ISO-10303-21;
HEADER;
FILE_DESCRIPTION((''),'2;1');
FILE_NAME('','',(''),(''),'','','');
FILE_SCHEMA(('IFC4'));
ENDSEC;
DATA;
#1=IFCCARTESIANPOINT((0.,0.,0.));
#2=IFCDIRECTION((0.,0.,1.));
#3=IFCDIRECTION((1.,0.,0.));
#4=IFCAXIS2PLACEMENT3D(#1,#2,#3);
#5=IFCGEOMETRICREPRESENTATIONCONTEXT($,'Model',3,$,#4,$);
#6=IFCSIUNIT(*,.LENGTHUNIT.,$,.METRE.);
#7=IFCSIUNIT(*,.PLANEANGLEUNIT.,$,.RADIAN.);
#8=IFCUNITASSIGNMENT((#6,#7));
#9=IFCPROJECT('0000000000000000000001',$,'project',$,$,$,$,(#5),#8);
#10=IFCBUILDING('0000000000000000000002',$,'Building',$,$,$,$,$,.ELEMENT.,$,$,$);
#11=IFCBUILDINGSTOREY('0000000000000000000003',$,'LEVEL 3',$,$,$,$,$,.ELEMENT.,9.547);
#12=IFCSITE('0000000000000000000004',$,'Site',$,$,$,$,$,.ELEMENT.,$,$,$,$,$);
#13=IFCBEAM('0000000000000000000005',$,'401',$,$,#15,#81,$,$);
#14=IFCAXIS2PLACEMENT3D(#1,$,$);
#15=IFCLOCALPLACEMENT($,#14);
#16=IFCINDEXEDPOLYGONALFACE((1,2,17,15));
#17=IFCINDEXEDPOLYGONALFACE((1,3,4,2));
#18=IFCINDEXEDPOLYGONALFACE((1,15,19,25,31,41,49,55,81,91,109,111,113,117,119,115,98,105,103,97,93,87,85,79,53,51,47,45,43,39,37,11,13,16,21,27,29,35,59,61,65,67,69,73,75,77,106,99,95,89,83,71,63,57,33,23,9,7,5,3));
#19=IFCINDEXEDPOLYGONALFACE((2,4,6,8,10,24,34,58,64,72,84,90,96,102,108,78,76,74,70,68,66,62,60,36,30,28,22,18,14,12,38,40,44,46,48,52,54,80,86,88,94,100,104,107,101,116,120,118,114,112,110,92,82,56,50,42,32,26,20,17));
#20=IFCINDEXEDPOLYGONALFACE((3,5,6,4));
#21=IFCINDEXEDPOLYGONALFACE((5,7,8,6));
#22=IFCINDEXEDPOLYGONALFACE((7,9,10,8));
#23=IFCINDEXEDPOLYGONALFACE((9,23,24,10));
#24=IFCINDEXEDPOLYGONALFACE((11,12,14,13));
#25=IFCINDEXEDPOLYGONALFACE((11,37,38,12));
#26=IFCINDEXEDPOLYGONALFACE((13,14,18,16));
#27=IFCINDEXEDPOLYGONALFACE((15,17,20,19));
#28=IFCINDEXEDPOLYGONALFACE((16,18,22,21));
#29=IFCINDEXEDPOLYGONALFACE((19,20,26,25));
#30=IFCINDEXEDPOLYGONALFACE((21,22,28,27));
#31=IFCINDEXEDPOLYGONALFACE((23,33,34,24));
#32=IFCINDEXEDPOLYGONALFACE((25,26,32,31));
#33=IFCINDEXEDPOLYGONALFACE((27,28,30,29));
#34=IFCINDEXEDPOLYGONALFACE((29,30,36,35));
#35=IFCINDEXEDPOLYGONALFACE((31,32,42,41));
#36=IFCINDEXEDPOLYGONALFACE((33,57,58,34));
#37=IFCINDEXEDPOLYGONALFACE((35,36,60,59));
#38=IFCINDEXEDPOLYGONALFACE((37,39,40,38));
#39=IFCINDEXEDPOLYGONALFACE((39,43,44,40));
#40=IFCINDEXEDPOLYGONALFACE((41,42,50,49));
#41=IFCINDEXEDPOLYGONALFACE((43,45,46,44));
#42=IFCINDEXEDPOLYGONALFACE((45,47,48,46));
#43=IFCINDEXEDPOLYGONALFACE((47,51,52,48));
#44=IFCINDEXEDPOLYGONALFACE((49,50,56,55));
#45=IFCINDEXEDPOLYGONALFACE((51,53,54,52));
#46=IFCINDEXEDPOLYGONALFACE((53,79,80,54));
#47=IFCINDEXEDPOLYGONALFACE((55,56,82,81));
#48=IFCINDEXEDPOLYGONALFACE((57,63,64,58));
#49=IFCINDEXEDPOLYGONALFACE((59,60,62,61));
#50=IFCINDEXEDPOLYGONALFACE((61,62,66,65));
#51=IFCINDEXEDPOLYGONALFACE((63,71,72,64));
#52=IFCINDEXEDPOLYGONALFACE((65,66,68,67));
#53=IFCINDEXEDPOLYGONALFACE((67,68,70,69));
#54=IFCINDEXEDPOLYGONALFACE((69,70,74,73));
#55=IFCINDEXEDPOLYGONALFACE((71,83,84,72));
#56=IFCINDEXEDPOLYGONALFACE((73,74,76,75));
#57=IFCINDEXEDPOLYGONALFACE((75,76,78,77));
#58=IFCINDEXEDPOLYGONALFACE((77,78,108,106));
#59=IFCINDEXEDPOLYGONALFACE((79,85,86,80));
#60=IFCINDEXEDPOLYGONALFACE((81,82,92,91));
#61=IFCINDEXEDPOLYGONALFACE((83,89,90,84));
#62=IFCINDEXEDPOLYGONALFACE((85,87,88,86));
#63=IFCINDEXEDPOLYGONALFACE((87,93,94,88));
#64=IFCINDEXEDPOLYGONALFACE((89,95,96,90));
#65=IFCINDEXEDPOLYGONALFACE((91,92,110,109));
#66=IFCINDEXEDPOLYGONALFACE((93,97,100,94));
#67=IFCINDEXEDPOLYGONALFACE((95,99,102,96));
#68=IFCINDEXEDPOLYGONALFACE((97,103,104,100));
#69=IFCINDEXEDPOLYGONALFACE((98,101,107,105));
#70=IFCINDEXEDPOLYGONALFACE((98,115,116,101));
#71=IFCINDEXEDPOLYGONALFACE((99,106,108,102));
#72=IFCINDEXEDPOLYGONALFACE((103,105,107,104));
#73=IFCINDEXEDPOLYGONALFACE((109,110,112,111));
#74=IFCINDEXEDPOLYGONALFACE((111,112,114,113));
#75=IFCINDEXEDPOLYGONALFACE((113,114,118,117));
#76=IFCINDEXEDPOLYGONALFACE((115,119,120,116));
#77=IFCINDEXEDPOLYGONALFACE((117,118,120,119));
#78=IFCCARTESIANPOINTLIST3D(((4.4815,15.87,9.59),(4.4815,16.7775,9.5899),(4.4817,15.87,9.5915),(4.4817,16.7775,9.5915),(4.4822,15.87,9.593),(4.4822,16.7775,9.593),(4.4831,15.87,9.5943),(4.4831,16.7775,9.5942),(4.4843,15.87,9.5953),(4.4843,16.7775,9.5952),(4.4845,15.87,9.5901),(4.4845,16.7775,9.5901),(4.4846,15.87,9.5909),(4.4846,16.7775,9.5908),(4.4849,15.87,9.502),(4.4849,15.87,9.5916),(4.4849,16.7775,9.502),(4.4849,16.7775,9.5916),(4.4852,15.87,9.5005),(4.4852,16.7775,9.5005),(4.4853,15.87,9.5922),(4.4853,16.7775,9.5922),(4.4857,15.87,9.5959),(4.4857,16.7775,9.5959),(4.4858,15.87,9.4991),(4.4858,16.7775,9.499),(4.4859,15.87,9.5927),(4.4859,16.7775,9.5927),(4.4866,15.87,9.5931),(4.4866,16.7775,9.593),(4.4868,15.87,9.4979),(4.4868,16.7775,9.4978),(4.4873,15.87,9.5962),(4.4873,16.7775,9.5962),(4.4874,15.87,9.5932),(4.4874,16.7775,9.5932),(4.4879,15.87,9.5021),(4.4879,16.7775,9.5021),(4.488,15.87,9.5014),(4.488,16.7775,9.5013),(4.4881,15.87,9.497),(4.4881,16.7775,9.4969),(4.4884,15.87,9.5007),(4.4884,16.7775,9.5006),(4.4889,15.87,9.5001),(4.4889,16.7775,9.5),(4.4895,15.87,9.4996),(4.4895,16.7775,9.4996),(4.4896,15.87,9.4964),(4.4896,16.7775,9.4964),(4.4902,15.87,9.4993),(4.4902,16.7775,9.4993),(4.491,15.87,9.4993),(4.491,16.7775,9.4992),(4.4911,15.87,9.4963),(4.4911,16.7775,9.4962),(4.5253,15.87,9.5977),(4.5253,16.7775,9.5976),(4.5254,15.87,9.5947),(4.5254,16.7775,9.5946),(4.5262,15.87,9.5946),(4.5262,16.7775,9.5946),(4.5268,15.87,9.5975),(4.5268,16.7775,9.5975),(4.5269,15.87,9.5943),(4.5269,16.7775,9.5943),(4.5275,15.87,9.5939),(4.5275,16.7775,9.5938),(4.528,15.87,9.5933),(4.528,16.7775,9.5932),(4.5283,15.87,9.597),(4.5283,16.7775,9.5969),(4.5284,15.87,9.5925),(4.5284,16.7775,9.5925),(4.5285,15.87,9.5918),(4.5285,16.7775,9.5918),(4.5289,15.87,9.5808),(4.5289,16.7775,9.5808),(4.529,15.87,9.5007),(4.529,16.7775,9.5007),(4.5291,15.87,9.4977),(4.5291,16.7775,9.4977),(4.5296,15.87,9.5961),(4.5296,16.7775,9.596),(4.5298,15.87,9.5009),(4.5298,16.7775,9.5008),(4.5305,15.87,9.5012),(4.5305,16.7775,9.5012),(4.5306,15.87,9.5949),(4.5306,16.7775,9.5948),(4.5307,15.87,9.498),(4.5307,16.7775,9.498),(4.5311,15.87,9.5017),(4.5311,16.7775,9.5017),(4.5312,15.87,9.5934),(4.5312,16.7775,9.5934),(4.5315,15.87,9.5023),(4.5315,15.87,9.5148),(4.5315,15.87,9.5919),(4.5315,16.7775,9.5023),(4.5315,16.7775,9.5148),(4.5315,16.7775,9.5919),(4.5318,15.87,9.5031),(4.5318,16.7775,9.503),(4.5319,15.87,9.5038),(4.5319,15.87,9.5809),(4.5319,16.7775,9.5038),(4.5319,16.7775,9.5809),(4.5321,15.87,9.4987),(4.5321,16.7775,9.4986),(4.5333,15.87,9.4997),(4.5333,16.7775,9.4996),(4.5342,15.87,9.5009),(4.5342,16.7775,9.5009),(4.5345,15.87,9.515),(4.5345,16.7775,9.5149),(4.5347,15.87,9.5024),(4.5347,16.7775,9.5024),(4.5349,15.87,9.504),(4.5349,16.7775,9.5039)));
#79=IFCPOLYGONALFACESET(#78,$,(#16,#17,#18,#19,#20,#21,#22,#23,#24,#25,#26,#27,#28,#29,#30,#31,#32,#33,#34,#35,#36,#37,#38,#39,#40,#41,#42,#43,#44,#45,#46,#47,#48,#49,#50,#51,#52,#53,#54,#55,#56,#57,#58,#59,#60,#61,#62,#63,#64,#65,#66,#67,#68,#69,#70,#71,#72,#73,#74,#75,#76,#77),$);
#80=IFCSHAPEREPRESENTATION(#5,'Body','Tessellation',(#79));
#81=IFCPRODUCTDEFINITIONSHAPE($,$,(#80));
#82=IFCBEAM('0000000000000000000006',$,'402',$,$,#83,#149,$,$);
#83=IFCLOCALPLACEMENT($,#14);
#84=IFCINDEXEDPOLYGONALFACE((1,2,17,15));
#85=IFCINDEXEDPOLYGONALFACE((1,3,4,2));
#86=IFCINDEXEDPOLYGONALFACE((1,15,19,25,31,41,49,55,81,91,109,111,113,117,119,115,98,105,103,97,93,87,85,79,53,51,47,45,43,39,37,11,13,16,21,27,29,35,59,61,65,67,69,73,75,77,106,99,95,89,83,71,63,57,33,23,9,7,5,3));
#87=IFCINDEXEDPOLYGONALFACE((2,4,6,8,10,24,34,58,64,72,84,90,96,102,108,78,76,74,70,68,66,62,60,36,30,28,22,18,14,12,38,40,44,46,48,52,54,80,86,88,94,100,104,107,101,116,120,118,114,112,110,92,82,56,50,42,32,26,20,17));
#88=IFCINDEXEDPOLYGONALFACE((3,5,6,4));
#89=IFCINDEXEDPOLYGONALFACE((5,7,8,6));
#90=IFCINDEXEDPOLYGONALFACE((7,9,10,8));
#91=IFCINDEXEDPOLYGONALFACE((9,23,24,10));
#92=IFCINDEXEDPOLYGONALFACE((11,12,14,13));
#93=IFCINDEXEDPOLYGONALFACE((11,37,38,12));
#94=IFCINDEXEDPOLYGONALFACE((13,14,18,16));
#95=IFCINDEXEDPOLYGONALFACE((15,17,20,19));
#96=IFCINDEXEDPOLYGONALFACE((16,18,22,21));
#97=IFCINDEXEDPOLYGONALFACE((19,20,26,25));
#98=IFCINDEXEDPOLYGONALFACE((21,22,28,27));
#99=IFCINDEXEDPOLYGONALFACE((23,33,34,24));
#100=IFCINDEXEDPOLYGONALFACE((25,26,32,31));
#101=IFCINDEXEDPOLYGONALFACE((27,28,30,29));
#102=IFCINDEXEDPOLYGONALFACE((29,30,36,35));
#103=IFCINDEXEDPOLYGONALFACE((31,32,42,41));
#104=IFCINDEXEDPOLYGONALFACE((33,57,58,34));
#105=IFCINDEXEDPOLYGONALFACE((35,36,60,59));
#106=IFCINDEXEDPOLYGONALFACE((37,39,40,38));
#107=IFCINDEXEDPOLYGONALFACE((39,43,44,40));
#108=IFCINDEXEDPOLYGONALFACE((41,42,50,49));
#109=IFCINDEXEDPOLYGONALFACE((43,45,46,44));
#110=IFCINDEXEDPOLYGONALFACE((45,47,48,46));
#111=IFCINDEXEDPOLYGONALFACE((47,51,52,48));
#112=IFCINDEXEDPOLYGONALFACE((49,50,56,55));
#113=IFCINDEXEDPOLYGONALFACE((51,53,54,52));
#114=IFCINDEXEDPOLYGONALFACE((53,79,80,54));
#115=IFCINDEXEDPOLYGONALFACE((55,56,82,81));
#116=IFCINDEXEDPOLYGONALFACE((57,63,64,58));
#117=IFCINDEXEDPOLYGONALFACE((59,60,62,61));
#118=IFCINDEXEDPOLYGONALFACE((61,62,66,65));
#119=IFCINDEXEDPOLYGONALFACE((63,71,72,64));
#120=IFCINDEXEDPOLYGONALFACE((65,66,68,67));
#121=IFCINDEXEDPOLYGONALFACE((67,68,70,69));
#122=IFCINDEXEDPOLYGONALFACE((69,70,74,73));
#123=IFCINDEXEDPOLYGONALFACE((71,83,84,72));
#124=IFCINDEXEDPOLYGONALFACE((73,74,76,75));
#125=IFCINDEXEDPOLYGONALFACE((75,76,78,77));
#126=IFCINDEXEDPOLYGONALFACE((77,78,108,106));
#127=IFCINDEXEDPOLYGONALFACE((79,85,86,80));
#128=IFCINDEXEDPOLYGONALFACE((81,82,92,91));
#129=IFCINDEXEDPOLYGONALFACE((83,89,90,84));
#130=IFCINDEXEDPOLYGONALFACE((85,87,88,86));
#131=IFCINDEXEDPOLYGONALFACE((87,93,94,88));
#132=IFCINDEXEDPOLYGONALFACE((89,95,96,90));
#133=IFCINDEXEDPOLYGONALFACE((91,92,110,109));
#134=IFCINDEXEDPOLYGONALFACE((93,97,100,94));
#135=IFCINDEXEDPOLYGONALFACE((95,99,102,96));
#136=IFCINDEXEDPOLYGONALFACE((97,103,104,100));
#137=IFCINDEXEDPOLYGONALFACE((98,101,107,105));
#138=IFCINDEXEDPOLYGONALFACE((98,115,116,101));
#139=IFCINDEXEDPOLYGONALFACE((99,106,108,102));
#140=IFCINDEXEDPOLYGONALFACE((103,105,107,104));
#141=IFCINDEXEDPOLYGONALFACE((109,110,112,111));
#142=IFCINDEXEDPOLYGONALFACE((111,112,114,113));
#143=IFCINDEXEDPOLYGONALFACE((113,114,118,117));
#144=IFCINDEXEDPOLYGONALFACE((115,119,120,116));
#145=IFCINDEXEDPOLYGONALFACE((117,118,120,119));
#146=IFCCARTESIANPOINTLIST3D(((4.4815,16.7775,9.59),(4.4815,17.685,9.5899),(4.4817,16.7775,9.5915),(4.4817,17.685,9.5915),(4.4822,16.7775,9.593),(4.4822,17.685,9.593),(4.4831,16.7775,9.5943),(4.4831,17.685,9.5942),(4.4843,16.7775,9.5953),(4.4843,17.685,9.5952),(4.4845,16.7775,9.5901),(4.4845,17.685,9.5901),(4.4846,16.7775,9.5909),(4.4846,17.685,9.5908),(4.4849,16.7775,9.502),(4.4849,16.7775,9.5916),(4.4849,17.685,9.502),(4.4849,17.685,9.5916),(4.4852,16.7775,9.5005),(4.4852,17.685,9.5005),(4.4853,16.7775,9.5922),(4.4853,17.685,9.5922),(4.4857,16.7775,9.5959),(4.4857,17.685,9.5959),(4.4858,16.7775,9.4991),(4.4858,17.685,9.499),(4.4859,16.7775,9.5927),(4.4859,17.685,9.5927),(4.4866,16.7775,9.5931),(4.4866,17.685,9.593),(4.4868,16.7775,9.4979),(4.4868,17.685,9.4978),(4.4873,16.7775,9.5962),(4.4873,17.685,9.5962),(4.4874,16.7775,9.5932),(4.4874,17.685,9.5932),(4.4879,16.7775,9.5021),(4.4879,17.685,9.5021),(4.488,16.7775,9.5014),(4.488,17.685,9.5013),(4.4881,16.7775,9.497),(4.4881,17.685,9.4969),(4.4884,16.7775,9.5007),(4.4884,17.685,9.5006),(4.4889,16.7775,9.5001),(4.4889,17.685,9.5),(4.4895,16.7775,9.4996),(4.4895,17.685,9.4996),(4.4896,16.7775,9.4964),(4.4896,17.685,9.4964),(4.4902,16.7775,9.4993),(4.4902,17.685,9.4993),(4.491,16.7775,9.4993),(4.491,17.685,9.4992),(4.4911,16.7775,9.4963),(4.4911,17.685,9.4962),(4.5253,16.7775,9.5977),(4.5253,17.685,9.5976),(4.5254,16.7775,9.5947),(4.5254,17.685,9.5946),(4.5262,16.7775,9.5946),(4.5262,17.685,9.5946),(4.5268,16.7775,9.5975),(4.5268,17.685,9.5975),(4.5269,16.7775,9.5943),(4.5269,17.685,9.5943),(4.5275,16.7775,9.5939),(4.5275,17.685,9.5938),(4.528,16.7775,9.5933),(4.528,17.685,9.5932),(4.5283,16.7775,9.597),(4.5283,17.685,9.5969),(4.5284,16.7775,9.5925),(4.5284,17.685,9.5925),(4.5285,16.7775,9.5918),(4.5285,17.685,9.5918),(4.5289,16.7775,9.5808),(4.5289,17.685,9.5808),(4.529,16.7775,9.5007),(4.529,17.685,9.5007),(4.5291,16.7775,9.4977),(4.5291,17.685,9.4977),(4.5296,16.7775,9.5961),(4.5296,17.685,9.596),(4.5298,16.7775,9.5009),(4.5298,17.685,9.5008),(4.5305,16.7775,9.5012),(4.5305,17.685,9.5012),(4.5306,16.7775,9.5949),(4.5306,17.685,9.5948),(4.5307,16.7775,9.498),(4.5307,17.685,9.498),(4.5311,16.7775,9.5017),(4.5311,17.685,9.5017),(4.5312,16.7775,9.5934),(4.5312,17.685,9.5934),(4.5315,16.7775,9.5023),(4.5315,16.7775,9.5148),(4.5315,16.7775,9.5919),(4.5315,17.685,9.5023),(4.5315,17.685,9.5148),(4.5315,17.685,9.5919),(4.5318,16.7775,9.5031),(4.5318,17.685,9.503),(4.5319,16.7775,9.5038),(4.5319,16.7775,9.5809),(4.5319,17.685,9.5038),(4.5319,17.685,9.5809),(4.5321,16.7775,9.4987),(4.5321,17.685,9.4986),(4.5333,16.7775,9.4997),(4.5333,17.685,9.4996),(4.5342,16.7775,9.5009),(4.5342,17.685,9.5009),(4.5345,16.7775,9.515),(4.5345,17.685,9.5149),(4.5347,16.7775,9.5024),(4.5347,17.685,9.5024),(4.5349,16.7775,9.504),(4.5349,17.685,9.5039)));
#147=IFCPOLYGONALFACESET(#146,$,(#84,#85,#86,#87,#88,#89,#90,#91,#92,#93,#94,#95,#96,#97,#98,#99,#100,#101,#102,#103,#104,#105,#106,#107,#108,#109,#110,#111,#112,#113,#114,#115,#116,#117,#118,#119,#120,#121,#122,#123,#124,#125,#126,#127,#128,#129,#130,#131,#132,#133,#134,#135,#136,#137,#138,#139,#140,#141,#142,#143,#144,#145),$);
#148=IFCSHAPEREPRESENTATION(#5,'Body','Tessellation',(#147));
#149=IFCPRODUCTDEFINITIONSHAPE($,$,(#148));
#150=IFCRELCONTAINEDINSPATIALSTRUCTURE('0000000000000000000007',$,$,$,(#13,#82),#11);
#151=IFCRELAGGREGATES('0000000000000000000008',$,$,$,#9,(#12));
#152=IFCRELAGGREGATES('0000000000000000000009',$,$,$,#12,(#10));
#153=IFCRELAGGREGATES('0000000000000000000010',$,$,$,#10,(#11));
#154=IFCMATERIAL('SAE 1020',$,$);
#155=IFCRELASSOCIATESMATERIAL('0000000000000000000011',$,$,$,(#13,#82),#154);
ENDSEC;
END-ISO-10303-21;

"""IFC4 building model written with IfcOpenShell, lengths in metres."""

from ifc_helpers import new_model, si_unit, frame, origin_with_axes, origin_2d_with_axis, place, context, project, spatial, c_section, extrude, material, material_profile, profile_set, profile_usage, element, save


model = new_model("IFC4")

# Units and contexts
model_context = context("Model", 3, world=origin_with_axes())
ifc_project = project(units=[si_unit("LENGTHUNIT", "METRE"), si_unit("PLANEANGLEUNIT", "RADIAN")], contexts=[model_context])

# Site, building, storey
site = spatial("IfcSite", under=ifc_project, Name="Site", CompositionType="ELEMENT")
building = spatial("IfcBuilding", under=site, Name="Building", CompositionType="ELEMENT")
storey = spatial("IfcBuildingStorey", under=building, Name="LEVEL 3", CompositionType="ELEMENT", Elevation=9.547)

# Beams
ifc_material = material(Name="SAE 1020")
ifc_material_profile_1 = material_profile(ifc_material, c_section(Depth=0.1, Width=0.05, WallThickness=0.003, Girth=0.017, InternalFilletRadius=0.003, at=origin_2d_with_axis()))
ifc_profile_set_1 = profile_set([ifc_material_profile_1])
ifc_profile_usage_1 = profile_usage(ifc_profile_set_1, cardinal=10)
beam_1_placement = place(None, frame((4.5082, 15.87, 9.547), z_axis=(0.0, 1.0, -0.00003), x_axis=(0.999256, 0.000001, 0.038562)))
element("IfcBeam", 1, at=beam_1_placement, inside=storey, material=ifc_profile_usage_1, Name="401", context=model_context, shape_type="SweptSolid", body=[
    extrude(c_section(Depth=0.1, Width=0.05, WallThickness=0.003, Girth=0.017, InternalFilletRadius=0.003, at=origin_2d_with_axis()), origin_with_axes(), (0.0, 0.0, 1.0), 0.9075),
])
ifc_material_profile_2 = material_profile(ifc_material, c_section(Depth=0.1, Width=0.05, WallThickness=0.003, Girth=0.017, InternalFilletRadius=0.003, at=origin_2d_with_axis()))
ifc_profile_set_2 = profile_set([ifc_material_profile_2])
ifc_profile_usage_2 = profile_usage(ifc_profile_set_2, cardinal=10)
beam_2_placement = place(None, frame((4.5082, 16.7775, 9.547), z_axis=(0.0, 1.0, -0.00003), x_axis=(0.999256, 0.000001, 0.038562)))
element("IfcBeam", 2, at=beam_2_placement, inside=storey, material=ifc_profile_usage_2, Name="402", context=model_context, shape_type="SweptSolid", body=[
    extrude(c_section(Depth=0.1, Width=0.05, WallThickness=0.003, Girth=0.017, InternalFilletRadius=0.003, at=origin_2d_with_axis()), origin_with_axes(), (0.0, 0.0, 1.0), 0.9075),
])

save(model, "model.ifc")
